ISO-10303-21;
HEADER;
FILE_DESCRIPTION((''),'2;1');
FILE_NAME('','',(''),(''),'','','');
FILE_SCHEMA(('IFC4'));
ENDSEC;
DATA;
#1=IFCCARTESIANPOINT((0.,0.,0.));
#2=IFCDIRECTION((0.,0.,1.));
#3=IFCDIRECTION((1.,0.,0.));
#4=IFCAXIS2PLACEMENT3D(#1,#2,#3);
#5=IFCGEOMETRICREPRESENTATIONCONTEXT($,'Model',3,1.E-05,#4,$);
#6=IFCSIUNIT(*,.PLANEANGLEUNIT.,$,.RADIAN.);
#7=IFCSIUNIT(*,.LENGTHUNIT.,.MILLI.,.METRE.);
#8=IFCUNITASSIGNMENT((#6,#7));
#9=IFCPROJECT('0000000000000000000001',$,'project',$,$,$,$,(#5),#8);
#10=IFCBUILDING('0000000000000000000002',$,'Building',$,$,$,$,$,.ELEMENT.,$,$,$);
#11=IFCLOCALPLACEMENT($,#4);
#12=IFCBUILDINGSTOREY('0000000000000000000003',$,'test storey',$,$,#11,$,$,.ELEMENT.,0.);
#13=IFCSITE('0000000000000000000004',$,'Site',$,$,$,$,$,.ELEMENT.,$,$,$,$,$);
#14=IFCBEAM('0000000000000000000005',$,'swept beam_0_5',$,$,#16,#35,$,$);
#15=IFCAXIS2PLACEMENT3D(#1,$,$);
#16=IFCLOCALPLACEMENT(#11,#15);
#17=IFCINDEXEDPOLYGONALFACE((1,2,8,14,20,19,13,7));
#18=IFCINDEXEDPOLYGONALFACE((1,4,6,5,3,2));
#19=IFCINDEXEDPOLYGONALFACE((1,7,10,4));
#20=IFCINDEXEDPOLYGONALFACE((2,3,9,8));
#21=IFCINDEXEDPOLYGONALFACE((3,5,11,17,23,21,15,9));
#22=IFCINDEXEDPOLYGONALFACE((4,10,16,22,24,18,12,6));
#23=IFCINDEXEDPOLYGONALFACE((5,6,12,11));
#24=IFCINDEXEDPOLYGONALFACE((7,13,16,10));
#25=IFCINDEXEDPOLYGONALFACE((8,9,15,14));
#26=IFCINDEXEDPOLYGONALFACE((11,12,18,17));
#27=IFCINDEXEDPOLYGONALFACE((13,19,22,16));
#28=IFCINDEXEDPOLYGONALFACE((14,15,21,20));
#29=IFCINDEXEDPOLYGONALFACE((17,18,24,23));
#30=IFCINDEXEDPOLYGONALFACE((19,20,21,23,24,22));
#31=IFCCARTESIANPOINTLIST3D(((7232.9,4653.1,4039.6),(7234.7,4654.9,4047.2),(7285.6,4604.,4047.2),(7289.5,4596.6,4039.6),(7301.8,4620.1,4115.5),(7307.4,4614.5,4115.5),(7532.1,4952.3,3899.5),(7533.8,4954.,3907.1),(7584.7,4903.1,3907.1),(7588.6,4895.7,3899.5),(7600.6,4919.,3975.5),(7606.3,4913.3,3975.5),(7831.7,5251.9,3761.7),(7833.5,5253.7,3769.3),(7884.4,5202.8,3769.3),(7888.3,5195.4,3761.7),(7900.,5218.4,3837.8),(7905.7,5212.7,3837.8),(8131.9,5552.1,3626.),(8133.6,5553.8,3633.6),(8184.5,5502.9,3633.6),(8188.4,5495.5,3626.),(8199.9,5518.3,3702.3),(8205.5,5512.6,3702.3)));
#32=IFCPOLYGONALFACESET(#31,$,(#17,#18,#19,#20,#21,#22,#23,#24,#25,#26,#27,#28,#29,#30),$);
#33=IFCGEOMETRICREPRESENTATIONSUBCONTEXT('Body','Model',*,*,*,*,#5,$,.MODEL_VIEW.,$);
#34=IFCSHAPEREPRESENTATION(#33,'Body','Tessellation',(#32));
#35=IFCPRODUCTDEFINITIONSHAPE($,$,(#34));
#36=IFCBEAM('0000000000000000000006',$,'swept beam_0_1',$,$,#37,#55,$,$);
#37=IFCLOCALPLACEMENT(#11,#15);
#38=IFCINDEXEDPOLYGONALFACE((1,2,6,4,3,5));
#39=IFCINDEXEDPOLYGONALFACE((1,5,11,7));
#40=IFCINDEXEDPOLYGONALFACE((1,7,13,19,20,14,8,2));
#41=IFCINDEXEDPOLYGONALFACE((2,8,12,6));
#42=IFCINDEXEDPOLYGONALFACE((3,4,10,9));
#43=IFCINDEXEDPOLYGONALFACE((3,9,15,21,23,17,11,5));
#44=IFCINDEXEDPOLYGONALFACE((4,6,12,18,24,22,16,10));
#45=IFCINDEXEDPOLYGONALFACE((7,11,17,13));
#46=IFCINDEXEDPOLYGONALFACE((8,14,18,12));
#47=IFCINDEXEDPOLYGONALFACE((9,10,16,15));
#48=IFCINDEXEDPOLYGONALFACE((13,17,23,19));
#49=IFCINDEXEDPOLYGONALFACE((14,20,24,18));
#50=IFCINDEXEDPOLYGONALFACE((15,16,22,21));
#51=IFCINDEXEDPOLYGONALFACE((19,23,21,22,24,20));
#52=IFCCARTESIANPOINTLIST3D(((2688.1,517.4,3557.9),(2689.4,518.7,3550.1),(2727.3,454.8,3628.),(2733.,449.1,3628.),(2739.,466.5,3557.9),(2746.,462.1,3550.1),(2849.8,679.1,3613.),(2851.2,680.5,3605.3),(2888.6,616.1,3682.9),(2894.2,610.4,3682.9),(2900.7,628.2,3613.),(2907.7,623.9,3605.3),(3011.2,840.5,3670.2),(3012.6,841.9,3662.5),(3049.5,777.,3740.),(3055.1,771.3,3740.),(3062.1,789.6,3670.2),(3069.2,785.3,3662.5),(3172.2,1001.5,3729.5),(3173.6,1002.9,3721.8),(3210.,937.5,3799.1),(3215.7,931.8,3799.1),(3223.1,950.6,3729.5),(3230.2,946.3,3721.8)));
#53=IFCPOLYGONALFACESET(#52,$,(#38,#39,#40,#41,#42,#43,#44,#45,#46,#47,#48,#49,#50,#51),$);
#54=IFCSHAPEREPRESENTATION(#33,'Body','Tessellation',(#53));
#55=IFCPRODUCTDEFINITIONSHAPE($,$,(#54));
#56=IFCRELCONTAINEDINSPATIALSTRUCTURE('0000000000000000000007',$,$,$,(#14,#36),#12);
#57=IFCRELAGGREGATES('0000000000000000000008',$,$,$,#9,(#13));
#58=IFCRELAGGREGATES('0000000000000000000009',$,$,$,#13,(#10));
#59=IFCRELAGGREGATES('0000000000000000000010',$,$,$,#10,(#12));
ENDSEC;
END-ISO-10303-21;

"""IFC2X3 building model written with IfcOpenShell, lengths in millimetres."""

from ifc_helpers import new_model, entity, si_unit, origin_with_axes, place, context, subcontext, project, spatial, element, save


model = new_model("IFC2X3")

# Units and contexts
model_context = context("Model", 3, precision=1e-05, world=origin_with_axes())
body_context = subcontext(model_context, "Body", "Model", "MODEL_VIEW")
ifc_project = project(units=[si_unit("PLANEANGLEUNIT", "RADIAN"), si_unit("LENGTHUNIT", "METRE", prefix="MILLI")], contexts=[model_context])

# Site, building, storey
site = spatial("IfcSite", under=ifc_project, Name="Site", CompositionType="ELEMENT")
building = spatial("IfcBuilding", under=site, Name="Building", CompositionType="ELEMENT")
storey_placement = place(None, origin_with_axes())
storey = spatial("IfcBuildingStorey", under=building, at=storey_placement, Name="test storey", CompositionType="ELEMENT", Elevation=0.0)

# Beams
beam_1_placement = place(storey_placement, origin_with_axes())
element("IfcBeam", 1, at=beam_1_placement, inside=storey, Name="swept beam_0_5", context=body_context, shape_type="SweptSolid", body=[
    entity("IfcRevolvedAreaSolid", entity("IfcArbitraryClosedProfileDef", "AREA", None, entity("IfcPolyline", [entity("IfcCartesianPoint", [-80.0, 40.0]), entity("IfcCartesianPoint", [-80.0, 32.0]), entity("IfcCartesianPoint", [-8.0, 32.0]), entity("IfcCartesianPoint", [-8.0, -40.0]), entity("IfcCartesianPoint", [0.0, -40.0]), entity("IfcCartesianPoint", [0.0, 40.0]), entity("IfcCartesianPoint", [-80.0, 40.0])])), entity("IfcAxis2Placement3D", entity("IfcCartesianPoint", [7261.2, 4624.9, 4039.6]), entity("IfcDirection", [-0.6707, -0.6707, 0.3168]), entity("IfcDirection", [-0.224, -0.224, -0.9485])), entity("IfcAxis1Placement", entity("IfcCartesianPoint", [-85334.6, 0.0, 0.0]), entity("IfcDirection", [0.0, 1.0, 0.0])), 0.015666),
])
beam_2_placement = place(storey_placement, origin_with_axes())
element("IfcBeam", 2, at=beam_2_placement, inside=storey, Name="swept beam_0_1", context=body_context, shape_type="SweptSolid", body=[
    entity("IfcRevolvedAreaSolid", entity("IfcArbitraryClosedProfileDef", "AREA", None, entity("IfcPolyline", [entity("IfcCartesianPoint", [-80.0, 40.0]), entity("IfcCartesianPoint", [-80.0, 32.0]), entity("IfcCartesianPoint", [-8.0, 32.0]), entity("IfcCartesianPoint", [-8.0, -40.0]), entity("IfcCartesianPoint", [0.0, -40.0]), entity("IfcCartesianPoint", [0.0, 40.0]), entity("IfcCartesianPoint", [-80.0, 40.0])])), entity("IfcAxis2Placement3D", entity("IfcCartesianPoint", [2717.7, 490.4, 3550.1]), entity("IfcDirection", [-0.6882, -0.6882, -0.2297]), entity("IfcDirection", [0.1624, 0.1624, -0.9733])), entity("IfcAxis1Placement", entity("IfcCartesianPoint", [-25642.9, 0.0, 0.0]), entity("IfcDirection", [0.0, 1.0, 0.0])), 0.027532),
])

save(model, "model.ifc")
